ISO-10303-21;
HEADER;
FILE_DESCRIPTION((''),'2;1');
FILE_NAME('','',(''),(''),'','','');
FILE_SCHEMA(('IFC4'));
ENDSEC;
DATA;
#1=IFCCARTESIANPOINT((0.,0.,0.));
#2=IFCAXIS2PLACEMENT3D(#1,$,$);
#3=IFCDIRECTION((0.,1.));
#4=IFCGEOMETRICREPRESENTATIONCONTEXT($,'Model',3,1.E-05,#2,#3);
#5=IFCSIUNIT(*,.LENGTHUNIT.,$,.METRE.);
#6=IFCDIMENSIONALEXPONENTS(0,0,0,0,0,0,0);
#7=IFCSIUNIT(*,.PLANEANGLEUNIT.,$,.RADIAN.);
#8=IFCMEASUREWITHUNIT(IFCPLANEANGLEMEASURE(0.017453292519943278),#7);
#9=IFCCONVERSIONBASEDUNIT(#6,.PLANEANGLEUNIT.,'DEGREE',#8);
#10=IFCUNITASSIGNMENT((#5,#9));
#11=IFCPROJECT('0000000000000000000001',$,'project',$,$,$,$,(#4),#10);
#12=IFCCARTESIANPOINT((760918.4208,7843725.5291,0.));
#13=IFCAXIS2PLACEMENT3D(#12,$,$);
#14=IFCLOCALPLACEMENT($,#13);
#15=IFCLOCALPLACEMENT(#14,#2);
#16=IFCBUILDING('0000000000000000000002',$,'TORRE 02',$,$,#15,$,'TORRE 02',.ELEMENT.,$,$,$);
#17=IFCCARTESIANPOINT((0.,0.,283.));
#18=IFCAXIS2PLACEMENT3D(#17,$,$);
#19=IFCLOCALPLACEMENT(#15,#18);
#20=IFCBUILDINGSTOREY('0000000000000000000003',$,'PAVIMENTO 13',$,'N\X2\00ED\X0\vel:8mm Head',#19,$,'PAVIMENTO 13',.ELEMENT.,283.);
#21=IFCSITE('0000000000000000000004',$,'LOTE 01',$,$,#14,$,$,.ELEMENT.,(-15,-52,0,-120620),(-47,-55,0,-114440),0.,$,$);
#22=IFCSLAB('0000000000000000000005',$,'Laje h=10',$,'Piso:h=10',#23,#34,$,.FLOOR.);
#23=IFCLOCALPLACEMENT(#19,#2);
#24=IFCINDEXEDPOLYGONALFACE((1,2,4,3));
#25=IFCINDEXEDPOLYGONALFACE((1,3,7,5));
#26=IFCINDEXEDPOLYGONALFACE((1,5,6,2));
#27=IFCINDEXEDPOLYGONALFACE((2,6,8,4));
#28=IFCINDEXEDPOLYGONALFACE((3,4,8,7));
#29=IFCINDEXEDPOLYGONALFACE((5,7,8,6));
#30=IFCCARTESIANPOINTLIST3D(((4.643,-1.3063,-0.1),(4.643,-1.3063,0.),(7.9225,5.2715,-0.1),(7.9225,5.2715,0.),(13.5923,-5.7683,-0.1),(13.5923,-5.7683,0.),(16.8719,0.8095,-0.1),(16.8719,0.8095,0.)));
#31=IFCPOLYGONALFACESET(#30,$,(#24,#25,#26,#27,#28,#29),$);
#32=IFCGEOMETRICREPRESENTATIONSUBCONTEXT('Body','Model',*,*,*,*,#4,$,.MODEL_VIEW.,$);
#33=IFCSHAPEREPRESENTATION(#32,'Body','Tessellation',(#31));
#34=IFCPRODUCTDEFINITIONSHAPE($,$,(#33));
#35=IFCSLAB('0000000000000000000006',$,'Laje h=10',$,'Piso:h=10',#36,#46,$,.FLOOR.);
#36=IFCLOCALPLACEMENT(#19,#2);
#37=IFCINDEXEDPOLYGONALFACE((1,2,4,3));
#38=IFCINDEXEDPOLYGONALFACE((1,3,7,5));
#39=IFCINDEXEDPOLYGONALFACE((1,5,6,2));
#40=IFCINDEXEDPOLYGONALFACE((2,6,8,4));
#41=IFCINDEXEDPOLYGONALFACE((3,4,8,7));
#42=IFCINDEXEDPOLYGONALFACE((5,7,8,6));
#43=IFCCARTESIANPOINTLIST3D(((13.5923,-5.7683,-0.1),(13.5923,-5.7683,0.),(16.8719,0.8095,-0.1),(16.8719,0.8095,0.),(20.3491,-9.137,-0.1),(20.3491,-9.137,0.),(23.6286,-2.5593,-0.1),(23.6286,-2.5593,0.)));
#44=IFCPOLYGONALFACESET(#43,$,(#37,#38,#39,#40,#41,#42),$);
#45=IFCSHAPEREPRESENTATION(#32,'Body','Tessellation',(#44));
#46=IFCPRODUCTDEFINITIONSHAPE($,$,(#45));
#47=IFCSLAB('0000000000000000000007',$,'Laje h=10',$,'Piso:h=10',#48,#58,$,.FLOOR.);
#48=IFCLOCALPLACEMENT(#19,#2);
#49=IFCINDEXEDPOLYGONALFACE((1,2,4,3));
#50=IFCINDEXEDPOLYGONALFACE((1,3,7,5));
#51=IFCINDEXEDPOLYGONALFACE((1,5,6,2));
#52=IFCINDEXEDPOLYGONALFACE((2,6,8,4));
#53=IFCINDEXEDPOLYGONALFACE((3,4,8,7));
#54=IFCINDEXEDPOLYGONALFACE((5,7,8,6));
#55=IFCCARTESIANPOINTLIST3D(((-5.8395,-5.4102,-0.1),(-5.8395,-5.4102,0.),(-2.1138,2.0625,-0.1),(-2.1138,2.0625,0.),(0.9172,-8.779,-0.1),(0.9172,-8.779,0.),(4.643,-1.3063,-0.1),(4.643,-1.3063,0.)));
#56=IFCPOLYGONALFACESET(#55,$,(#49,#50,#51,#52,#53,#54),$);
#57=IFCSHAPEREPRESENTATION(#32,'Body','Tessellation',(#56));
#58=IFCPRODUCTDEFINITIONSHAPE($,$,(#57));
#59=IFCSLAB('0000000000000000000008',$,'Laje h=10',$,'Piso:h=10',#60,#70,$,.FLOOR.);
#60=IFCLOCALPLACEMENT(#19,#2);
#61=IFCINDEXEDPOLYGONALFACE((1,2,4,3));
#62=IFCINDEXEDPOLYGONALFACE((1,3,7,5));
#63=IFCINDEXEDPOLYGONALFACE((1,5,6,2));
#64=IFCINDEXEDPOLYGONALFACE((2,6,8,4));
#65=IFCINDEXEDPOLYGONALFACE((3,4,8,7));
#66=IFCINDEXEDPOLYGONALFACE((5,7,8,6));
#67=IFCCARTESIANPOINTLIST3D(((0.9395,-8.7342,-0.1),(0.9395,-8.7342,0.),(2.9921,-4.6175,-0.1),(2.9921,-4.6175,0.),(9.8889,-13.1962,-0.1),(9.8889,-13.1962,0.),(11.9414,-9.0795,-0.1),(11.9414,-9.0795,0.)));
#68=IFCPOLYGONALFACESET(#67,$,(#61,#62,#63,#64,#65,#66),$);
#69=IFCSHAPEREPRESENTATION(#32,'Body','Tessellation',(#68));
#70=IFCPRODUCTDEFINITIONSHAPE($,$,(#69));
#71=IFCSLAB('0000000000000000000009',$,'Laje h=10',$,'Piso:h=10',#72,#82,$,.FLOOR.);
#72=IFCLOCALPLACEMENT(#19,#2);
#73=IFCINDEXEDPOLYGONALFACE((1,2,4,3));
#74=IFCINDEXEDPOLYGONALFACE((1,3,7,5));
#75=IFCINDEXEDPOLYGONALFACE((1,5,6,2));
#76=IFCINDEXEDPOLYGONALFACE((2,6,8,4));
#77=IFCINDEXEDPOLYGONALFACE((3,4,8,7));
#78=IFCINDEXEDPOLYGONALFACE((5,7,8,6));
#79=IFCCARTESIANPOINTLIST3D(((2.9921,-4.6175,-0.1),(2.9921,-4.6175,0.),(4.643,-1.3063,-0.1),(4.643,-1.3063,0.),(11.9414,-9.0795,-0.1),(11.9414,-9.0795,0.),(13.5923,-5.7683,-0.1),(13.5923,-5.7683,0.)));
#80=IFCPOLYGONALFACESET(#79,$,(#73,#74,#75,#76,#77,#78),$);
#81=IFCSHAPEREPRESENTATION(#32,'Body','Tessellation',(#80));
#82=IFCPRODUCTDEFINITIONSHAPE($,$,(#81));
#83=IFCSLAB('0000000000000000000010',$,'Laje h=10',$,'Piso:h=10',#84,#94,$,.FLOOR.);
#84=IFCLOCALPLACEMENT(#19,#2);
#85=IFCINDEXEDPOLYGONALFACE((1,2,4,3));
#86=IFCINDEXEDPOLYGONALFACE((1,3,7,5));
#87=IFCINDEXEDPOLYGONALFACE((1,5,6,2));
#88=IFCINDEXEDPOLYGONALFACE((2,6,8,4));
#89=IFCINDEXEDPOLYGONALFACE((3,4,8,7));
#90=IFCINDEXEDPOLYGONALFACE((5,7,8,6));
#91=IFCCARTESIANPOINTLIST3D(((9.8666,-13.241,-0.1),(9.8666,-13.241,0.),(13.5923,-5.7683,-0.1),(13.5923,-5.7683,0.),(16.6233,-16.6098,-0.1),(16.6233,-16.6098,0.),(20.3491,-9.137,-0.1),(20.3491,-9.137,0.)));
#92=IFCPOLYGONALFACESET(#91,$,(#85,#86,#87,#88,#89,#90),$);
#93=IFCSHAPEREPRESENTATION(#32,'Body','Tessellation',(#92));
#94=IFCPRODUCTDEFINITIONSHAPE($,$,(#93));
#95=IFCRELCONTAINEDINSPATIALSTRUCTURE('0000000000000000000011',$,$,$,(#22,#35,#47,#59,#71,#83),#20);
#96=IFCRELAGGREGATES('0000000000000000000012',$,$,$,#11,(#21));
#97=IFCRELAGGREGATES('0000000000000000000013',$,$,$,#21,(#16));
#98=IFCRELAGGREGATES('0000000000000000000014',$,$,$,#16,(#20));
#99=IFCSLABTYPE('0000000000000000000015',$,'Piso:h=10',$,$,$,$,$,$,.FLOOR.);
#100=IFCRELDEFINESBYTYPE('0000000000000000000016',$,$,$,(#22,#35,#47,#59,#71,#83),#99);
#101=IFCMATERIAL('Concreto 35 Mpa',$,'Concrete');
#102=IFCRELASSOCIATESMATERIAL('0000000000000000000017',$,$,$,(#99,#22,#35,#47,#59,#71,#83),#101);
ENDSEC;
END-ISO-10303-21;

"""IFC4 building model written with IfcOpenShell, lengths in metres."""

from ifc_helpers import new_model, entity, si_unit, converted_unit, direction, frame, origin, place, context, subcontext, project, spatial, indexed_curve, outline, extrude, material, type_object, element, save


model = new_model("IFC4")

# Units and contexts
model_context = context("Model", 3, precision=1e-05, world=origin(), true_north=direction((0.0, 1.0)))
body_context = subcontext(model_context, "Body", "Model", "MODEL_VIEW")
ifc_project = project(units=[si_unit("LENGTHUNIT", "METRE"), converted_unit("PLANEANGLEUNIT", "DEGREE", entity("IfcPlaneAngleMeasure", 0.017453292519943278), si_unit("PLANEANGLEUNIT", "RADIAN"), dimensions=[0, 0, 0, 0, 0, 0, 0])], contexts=[model_context])

# Site, building, storey
site_placement = place(None, frame((760918.4208, 7843725.5291, 0.0)))
site = spatial("IfcSite", under=ifc_project, at=site_placement, Name="LOTE 01", CompositionType="ELEMENT", RefLatitude=(-15, -52, 0, -120620), RefLongitude=(-47, -55, 0, -114440), RefElevation=0.0)
building_placement = place(site_placement, origin())
building = spatial("IfcBuilding", under=site, at=building_placement, Name="TORRE 02", LongName="TORRE 02", CompositionType="ELEMENT")
storey_placement = place(building_placement, frame((0.0, 0.0, 283.0)))
storey = spatial("IfcBuildingStorey", under=building, at=storey_placement, Name="PAVIMENTO 13", ObjectType="Nível:8mm Head", LongName="PAVIMENTO 13", CompositionType="ELEMENT", Elevation=283.0)

# Slabs
ifc_material_1 = material(Name="Concreto 35 Mpa", Category="Concrete")
slab_type = type_object("IfcSlabType", Name="Piso:h=10", PredefinedType="FLOOR", material=ifc_material_1)
slab_1_placement = place(storey_placement, origin())
element("IfcSlab", 1, at=slab_1_placement, inside=storey, type_object=slab_type, material=ifc_material_1, Name="Laje h=10", ObjectType="Piso:h=10", PredefinedType="FLOOR", context=body_context, shape_type="SweptSolid", body=[
    extrude(outline(indexed_curve([(-3.675, -5.0), (3.675, -5.0), (3.675, 5.0), (-3.675, 5.0), (-3.675, -5.0)], self_intersect=False)), frame((10.7574, -0.2484, 0.0), z_axis=(0.0, 0.0, -1.0), x_axis=(-0.446198, -0.894934, 0.0)), (0.0, 0.0, 1.0), 0.1),
])
slab_2_placement = place(storey_placement, origin())
element("IfcSlab", 2, at=slab_2_placement, inside=storey, type_object=slab_type, material=ifc_material_1, Name="Laje h=10", ObjectType="Piso:h=10", PredefinedType="FLOOR", context=body_context, shape_type="SweptSolid", body=[
    extrude(outline(indexed_curve([(-3.675, -3.775), (3.675, -3.775), (3.675, 3.775), (-3.675, 3.775), (-3.675, -3.775)], self_intersect=False)), frame((18.6105, -4.1638, 0.0), z_axis=(0.0, 0.0, -1.0), x_axis=(-0.446198, -0.894934, 0.0)), (0.0, 0.0, 1.0), 0.1),
])
slab_3_placement = place(storey_placement, origin())
element("IfcSlab", 3, at=slab_3_placement, inside=storey, type_object=slab_type, material=ifc_material_1, Name="Laje h=10", ObjectType="Piso:h=10", PredefinedType="FLOOR", context=body_context, shape_type="SweptSolid", body=[
    extrude(outline(indexed_curve([(-4.175, -3.775), (4.175, -3.775), (4.175, 3.775), (-4.175, 3.775), (-4.175, -3.775)], self_intersect=False)), frame((-0.5983, -3.3582, 0.0), z_axis=(0.0, 0.0, -1.0), x_axis=(-0.446198, -0.894934, 0.0)), (0.0, 0.0, 1.0), 0.1),
])
slab_4_placement = place(storey_placement, origin())
element("IfcSlab", 4, at=slab_4_placement, inside=storey, type_object=slab_type, material=ifc_material_1, Name="Laje h=10", ObjectType="Piso:h=10", PredefinedType="FLOOR", context=body_context, shape_type="SweptSolid", body=[
    extrude(outline(indexed_curve([(-2.3, -5.0), (2.3, -5.0), (2.3, 5.0), (-2.3, 5.0), (-2.3, -5.0)], self_intersect=False)), frame((6.4405, -8.9069, 0.0), z_axis=(0.0, 0.0, -1.0), x_axis=(-0.446198, -0.894934, 0.0)), (0.0, 0.0, 1.0), 0.1),
])
slab_5_placement = place(storey_placement, origin())
element("IfcSlab", 5, at=slab_5_placement, inside=storey, type_object=slab_type, material=ifc_material_1, Name="Laje h=10", ObjectType="Piso:h=10", PredefinedType="FLOOR", context=body_context, shape_type="SweptSolid", body=[
    extrude(outline(indexed_curve([(-1.85, -5.0), (1.85, -5.0), (1.85, 5.0), (-1.85, 5.0), (-1.85, -5.0)], self_intersect=False)), frame((8.2922, -5.1929, 0.0), z_axis=(0.0, 0.0, -1.0), x_axis=(-0.446198, -0.894934, 0.0)), (0.0, 0.0, 1.0), 0.1),
])
slab_6_placement = place(storey_placement, origin())
element("IfcSlab", 6, at=slab_6_placement, inside=storey, type_object=slab_type, material=ifc_material_1, Name="Laje h=10", ObjectType="Piso:h=10", PredefinedType="FLOOR", context=body_context, shape_type="SweptSolid", body=[
    extrude(outline(indexed_curve([(-4.175, -3.775), (4.175, -3.775), (4.175, 3.775), (-4.175, 3.775), (-4.175, -3.775)], self_intersect=False)), frame((15.1078, -11.189, 0.0), z_axis=(0.0, 0.0, -1.0), x_axis=(-0.446198, -0.894934, 0.0)), (0.0, 0.0, 1.0), 0.1),
])

save(model, "model.ifc")
